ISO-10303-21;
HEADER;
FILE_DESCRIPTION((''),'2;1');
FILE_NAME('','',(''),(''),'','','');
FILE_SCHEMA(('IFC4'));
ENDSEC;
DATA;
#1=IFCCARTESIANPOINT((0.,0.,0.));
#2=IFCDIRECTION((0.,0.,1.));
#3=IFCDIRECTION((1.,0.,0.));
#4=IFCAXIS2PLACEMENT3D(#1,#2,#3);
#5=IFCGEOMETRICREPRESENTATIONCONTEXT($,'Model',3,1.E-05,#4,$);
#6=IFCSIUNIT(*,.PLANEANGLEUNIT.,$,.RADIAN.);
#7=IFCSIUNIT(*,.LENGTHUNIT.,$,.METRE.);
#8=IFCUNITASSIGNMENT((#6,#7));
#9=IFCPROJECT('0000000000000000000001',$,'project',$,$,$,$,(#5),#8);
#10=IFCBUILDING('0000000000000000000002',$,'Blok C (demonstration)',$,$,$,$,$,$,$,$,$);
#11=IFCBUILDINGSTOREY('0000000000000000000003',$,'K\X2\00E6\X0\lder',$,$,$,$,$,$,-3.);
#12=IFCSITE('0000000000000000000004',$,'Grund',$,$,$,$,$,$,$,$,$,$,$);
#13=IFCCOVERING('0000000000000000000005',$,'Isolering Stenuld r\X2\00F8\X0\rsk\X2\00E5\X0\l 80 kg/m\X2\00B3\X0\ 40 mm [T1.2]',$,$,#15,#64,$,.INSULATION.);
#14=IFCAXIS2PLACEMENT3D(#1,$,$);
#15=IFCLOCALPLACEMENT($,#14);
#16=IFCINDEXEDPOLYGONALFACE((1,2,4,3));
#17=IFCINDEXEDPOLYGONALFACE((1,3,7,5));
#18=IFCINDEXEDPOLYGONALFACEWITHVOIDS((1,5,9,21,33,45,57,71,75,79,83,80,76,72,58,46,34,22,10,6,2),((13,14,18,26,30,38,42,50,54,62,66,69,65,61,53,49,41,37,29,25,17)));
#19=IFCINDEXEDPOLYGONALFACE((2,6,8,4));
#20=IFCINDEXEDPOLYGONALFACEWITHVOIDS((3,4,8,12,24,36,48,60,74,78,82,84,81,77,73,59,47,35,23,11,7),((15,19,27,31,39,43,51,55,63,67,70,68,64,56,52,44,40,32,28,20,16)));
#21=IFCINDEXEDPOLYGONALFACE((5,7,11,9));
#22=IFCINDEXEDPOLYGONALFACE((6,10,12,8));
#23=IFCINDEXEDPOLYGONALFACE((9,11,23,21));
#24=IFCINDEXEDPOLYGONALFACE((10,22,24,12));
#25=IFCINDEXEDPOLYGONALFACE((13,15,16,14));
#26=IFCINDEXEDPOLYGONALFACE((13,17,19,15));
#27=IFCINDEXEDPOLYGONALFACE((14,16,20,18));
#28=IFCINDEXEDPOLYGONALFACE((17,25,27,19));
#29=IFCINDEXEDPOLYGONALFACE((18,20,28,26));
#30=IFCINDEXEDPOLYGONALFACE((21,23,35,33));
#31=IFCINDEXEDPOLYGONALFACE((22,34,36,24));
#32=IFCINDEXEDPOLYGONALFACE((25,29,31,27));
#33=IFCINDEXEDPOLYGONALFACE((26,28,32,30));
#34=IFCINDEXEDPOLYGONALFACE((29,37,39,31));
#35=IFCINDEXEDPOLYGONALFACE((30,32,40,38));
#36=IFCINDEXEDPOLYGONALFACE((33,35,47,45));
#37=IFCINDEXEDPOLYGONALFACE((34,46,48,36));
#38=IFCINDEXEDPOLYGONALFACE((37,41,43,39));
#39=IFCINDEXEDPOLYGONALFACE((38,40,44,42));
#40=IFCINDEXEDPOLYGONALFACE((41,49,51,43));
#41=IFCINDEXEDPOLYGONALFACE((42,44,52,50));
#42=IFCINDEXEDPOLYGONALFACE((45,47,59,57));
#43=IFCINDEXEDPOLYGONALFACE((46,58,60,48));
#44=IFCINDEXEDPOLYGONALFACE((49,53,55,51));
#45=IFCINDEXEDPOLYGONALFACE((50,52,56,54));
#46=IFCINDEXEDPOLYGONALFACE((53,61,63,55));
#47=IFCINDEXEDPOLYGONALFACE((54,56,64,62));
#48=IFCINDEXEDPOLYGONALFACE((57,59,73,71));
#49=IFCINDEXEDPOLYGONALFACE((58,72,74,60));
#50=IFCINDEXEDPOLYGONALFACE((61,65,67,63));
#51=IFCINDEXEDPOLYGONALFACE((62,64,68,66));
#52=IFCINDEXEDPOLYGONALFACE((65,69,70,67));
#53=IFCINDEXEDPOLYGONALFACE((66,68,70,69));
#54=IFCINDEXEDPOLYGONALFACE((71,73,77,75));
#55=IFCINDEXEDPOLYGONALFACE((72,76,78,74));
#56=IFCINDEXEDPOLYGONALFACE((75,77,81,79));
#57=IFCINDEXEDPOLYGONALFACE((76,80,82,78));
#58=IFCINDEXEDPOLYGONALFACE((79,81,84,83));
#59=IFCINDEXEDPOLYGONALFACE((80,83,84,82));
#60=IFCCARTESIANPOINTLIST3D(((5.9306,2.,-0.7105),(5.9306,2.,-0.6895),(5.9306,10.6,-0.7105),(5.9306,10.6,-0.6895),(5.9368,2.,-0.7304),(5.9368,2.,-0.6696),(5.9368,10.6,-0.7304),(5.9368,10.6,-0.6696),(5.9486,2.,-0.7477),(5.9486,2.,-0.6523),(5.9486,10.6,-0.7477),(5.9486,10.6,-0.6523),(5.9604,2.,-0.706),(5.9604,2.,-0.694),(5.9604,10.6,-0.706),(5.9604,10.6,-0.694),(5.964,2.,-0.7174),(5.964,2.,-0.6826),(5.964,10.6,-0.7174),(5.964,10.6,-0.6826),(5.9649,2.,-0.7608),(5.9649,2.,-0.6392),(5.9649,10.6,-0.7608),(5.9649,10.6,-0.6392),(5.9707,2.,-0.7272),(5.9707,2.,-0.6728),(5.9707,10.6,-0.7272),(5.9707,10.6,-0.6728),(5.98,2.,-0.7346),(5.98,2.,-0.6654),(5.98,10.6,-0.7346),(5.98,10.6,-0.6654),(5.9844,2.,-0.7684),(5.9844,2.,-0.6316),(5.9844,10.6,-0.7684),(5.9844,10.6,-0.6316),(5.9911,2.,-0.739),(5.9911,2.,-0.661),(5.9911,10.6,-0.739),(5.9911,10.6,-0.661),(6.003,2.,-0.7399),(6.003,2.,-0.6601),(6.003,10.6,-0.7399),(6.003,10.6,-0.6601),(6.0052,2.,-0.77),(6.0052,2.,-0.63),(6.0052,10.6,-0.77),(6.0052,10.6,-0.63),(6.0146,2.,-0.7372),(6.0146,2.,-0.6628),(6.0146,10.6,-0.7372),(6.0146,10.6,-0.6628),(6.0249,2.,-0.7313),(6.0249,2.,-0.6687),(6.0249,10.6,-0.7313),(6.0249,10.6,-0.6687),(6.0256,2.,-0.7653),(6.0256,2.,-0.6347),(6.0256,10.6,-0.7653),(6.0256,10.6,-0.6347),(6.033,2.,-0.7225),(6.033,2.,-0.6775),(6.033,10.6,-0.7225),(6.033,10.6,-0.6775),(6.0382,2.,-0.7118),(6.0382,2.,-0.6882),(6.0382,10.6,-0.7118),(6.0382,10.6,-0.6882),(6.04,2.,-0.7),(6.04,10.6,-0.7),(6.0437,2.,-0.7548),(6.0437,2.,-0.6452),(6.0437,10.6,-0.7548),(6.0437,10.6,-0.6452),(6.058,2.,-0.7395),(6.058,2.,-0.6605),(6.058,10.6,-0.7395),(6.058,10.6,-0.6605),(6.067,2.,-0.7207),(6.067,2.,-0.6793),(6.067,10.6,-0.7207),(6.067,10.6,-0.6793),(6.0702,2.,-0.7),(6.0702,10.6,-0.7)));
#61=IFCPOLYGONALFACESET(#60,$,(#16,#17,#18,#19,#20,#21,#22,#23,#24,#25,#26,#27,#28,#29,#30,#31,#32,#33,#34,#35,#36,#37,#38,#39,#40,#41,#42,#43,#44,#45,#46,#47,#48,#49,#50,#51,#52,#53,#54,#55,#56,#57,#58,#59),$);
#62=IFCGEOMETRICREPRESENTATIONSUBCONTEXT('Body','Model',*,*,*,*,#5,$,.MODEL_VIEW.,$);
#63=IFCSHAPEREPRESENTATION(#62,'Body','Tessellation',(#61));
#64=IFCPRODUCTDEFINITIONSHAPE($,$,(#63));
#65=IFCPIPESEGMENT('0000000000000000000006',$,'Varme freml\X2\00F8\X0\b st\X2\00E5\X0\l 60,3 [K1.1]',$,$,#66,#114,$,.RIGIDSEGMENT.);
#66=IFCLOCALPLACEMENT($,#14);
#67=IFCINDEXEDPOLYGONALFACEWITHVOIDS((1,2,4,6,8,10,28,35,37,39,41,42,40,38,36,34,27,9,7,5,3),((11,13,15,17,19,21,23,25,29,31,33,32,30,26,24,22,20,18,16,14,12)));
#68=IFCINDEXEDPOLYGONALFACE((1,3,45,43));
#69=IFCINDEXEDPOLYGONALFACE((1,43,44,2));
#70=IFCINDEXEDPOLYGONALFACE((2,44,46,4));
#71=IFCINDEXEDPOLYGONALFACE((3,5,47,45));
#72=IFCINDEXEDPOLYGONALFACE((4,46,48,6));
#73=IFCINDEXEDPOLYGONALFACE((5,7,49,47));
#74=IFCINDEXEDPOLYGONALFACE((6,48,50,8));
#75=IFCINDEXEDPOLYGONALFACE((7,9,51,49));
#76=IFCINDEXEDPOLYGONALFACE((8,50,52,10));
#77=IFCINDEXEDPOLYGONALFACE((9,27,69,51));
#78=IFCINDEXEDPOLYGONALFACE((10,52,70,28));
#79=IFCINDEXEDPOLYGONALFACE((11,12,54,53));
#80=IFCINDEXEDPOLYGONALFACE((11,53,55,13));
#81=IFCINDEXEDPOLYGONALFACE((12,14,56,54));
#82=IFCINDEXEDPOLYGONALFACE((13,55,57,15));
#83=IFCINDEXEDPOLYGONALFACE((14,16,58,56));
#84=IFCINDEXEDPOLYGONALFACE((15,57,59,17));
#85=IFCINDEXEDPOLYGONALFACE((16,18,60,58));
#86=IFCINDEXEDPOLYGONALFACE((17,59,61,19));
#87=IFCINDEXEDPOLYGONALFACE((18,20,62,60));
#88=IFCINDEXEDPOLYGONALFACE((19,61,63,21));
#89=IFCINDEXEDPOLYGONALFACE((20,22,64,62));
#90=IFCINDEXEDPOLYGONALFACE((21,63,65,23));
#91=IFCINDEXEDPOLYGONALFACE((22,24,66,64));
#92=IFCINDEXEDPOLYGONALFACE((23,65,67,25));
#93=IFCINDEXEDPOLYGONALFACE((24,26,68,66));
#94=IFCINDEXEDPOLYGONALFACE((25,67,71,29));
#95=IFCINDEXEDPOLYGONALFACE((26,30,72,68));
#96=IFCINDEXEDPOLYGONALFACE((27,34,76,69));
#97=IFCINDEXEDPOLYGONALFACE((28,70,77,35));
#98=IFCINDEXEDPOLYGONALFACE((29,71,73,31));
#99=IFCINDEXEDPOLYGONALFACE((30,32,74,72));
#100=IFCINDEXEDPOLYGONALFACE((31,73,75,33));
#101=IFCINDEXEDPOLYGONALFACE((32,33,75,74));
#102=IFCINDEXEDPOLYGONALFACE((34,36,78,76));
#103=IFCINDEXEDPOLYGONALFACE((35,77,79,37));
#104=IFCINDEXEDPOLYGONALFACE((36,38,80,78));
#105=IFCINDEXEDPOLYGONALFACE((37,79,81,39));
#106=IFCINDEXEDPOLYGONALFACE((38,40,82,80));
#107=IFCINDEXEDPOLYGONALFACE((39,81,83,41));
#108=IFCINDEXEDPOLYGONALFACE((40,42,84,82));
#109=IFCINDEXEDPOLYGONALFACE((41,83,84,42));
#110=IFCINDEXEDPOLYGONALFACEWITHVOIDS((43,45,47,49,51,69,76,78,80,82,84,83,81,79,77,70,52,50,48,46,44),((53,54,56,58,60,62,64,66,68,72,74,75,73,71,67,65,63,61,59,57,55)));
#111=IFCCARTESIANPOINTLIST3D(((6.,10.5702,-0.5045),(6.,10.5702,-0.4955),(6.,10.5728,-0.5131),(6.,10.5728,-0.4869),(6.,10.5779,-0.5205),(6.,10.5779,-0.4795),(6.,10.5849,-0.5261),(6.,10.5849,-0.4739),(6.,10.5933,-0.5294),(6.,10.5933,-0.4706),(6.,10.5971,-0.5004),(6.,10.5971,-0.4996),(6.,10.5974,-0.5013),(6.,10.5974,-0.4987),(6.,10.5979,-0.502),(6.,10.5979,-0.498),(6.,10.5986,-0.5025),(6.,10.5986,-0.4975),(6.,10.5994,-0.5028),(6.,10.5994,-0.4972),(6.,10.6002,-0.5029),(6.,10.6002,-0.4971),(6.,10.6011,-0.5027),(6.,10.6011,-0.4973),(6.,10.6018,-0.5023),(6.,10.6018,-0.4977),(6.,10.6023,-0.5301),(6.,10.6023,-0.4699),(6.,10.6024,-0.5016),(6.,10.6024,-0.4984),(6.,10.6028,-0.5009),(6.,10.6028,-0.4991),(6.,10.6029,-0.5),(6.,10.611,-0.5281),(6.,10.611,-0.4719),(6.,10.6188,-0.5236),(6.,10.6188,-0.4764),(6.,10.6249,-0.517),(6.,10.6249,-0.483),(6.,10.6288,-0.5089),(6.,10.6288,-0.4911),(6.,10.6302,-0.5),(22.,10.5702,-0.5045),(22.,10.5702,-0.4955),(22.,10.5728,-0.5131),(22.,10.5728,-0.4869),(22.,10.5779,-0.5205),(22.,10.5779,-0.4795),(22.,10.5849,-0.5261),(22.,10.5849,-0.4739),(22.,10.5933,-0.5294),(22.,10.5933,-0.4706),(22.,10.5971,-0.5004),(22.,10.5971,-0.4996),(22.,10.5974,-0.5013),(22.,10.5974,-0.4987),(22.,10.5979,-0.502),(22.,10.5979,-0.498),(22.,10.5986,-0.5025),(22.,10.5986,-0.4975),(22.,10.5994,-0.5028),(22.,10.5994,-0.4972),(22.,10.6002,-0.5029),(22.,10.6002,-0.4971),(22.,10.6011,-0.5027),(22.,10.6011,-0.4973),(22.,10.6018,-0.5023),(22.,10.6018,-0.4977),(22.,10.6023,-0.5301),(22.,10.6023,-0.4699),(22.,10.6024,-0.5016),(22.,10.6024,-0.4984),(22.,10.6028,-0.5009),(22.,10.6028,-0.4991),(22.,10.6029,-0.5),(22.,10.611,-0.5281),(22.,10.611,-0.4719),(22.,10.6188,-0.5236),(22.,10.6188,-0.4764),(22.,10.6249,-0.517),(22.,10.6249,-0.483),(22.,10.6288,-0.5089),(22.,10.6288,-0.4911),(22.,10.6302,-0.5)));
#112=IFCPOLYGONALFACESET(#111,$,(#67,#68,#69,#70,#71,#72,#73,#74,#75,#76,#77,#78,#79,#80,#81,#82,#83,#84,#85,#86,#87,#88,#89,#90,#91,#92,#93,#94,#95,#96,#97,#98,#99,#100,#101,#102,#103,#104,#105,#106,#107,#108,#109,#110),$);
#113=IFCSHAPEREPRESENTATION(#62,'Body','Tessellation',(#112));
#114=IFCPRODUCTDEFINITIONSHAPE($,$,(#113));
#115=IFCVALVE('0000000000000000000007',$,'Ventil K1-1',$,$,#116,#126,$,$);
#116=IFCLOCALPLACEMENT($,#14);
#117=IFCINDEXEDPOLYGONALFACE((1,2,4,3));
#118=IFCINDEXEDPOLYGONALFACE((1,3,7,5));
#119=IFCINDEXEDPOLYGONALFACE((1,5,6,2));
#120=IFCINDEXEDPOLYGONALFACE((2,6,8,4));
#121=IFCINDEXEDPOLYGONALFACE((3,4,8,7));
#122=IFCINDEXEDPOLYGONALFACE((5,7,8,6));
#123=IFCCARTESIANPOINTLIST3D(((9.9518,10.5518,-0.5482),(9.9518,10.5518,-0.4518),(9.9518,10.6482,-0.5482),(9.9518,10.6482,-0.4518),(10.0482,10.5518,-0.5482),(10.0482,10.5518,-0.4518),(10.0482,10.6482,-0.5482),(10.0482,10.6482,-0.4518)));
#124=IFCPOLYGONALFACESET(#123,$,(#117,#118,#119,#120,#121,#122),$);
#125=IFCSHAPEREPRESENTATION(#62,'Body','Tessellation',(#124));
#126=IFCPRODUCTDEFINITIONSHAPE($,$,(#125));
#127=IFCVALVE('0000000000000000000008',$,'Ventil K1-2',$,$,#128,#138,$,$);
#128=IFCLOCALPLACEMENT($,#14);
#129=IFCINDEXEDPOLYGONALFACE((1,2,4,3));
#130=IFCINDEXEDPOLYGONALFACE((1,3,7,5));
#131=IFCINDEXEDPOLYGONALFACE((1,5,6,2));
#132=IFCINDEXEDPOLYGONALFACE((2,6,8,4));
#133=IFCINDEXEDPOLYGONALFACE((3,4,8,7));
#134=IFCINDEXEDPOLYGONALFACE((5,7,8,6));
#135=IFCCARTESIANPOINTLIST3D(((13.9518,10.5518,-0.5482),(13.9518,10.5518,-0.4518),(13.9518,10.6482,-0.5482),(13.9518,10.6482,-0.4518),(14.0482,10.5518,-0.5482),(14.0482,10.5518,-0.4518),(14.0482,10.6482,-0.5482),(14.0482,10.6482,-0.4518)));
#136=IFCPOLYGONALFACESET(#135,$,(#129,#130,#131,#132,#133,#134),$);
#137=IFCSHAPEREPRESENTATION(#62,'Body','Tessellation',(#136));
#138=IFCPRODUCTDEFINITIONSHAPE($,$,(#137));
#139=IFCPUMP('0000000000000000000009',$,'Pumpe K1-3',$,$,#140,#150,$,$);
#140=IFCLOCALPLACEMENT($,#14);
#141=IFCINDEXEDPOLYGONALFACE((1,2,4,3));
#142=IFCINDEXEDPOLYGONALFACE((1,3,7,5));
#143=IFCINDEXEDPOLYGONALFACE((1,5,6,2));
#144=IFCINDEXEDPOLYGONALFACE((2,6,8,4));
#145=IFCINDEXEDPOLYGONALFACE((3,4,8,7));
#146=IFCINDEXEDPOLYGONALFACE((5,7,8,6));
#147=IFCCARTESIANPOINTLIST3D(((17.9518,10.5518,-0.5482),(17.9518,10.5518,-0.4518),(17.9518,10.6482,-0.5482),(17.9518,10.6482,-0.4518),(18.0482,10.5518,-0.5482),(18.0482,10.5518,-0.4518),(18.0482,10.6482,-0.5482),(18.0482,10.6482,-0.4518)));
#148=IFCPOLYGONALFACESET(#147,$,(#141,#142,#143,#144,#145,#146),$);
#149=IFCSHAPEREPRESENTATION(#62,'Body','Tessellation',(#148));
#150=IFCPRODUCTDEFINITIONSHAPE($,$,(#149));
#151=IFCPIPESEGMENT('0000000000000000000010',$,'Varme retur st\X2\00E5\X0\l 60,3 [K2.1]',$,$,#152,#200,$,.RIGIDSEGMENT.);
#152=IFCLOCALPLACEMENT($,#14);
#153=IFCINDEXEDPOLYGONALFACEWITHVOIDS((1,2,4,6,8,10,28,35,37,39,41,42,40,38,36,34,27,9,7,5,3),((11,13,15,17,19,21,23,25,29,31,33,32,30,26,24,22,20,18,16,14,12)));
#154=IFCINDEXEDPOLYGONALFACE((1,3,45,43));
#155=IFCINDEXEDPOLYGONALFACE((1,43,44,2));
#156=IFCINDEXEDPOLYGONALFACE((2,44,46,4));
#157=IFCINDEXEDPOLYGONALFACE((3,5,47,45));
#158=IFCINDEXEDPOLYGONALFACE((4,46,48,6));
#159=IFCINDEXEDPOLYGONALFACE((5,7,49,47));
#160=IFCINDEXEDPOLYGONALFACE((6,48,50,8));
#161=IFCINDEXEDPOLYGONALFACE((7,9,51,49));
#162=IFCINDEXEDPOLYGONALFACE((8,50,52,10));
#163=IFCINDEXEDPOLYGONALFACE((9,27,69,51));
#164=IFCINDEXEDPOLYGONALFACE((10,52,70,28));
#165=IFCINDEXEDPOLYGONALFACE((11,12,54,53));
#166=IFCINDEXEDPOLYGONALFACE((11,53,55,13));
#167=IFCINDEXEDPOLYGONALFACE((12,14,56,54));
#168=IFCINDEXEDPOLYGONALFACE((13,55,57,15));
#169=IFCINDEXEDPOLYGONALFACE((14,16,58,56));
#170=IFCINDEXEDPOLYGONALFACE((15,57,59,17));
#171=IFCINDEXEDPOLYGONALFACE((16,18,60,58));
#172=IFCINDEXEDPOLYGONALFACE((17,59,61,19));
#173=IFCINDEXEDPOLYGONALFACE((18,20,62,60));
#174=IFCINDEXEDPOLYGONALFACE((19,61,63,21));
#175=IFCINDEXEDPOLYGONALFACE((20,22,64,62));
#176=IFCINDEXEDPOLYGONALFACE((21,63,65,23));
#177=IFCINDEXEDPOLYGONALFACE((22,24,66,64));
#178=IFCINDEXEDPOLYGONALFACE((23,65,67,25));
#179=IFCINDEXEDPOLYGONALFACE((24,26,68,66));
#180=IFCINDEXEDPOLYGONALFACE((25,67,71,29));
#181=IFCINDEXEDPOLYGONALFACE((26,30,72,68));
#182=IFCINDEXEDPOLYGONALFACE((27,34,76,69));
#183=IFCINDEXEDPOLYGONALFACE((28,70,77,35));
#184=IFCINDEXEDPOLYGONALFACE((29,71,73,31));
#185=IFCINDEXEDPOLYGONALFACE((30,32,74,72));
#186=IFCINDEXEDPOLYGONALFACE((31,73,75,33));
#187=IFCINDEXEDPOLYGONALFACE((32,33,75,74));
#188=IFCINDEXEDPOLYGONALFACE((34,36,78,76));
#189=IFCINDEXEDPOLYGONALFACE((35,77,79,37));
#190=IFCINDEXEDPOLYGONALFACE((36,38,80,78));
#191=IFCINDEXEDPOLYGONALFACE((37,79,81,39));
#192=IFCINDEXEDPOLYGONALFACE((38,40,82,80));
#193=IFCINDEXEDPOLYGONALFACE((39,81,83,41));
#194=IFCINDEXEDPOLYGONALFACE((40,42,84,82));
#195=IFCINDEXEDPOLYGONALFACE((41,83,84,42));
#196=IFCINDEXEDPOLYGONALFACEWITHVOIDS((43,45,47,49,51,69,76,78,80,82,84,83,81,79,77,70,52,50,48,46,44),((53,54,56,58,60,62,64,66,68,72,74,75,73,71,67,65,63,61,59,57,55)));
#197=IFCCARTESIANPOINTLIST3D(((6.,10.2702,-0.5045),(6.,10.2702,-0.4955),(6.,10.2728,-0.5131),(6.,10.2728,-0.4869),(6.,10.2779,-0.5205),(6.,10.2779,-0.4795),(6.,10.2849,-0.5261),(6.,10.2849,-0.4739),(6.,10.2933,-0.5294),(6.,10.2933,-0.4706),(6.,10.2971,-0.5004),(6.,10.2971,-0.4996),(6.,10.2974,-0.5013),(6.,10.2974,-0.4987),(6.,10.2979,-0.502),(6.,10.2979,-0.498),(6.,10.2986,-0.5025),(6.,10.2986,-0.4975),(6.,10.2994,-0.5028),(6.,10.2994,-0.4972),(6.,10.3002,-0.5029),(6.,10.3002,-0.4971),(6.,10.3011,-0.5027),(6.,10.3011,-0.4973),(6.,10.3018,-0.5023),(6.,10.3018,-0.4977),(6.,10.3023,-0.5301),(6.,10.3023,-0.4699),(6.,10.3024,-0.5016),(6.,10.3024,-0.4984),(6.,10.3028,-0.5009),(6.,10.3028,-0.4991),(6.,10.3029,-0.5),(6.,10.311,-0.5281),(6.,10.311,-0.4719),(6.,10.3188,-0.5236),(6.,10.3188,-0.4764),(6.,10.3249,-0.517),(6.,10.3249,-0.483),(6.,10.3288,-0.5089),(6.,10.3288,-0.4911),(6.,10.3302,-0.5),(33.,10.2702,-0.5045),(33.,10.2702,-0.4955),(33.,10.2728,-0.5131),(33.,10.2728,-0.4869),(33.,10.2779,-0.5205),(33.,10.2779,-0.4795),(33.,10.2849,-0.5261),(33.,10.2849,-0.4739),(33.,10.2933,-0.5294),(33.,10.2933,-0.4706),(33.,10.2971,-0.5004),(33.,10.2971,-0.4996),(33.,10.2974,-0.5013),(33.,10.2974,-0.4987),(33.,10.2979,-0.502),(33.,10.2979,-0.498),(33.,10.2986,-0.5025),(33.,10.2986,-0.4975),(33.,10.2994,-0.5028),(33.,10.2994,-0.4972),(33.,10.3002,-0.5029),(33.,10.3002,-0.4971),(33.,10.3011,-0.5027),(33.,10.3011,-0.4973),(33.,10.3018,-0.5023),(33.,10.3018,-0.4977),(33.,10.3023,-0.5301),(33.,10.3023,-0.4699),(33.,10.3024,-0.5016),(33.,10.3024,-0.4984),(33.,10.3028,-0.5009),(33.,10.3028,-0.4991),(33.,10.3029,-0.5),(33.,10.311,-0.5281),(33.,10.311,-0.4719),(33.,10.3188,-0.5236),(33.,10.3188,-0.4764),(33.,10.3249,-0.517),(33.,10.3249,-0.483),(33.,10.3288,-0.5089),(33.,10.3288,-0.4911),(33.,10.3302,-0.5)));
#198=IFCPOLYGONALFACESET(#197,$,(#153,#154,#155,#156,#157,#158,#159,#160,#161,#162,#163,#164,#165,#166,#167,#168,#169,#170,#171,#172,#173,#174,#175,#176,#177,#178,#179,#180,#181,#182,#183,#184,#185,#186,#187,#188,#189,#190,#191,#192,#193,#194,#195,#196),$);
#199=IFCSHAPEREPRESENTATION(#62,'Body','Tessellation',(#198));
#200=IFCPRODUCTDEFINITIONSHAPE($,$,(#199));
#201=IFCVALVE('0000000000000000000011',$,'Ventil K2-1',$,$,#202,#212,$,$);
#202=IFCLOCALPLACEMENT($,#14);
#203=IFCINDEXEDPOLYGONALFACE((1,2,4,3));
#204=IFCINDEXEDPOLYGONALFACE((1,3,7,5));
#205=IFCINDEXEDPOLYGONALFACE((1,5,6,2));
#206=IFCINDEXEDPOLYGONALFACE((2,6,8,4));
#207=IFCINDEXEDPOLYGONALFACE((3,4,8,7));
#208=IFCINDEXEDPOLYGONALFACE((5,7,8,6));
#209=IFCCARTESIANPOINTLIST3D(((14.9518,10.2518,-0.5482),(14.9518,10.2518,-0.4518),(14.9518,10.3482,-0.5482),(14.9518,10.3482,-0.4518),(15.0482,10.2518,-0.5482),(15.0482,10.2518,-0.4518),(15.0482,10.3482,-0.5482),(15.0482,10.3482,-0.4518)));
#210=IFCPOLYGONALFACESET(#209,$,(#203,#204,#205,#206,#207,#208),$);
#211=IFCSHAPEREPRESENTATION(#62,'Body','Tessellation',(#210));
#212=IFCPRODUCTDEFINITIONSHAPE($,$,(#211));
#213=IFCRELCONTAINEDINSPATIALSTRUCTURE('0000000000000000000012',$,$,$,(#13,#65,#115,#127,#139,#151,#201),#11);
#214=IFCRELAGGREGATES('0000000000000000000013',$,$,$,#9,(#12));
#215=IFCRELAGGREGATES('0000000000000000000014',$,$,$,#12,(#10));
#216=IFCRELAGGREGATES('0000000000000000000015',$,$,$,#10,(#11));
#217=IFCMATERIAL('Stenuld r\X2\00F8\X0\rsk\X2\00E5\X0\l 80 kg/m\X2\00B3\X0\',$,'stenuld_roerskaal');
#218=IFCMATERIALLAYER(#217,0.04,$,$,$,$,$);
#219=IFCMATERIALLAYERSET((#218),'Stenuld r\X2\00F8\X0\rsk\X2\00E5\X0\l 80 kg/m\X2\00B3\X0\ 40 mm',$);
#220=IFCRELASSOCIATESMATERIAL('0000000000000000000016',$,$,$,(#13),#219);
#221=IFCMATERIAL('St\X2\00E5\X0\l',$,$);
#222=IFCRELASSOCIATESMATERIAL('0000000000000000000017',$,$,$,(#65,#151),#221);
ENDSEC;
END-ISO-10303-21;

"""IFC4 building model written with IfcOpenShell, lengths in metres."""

from ifc_helpers import new_model, si_unit, frame, origin_with_axes, place, context, subcontext, project, spatial, polyline, hollow_circle, outline, extrude, material, layer, layer_set, element, save


model = new_model("IFC4")

# Units and contexts
model_context = context("Model", 3, precision=1e-05, world=origin_with_axes())
body_context = subcontext(model_context, "Body", "Model", "MODEL_VIEW")
ifc_project = project(units=[si_unit("PLANEANGLEUNIT", "RADIAN"), si_unit("LENGTHUNIT", "METRE")], contexts=[model_context])

# Site, building, storey
site = spatial("IfcSite", under=ifc_project, Name="Grund")
building = spatial("IfcBuilding", under=site, Name="Blok C (demonstration)")
storey = spatial("IfcBuildingStorey", under=building, Name="Kælder", Elevation=-3.0)

# Covering
ifc_material_1 = material(Name="Stenuld rørskål 80 kg/m³", Category="stenuld_roerskaal")
ifc_layer_1 = layer(ifc_material_1, 0.04)
ifc_layer_set_1 = layer_set([ifc_layer_1], Name="Stenuld rørskål 80 kg/m³ 40 mm")
covering_1_placement = place(None, origin_with_axes())
element("IfcCovering", 1, at=covering_1_placement, inside=storey, material=ifc_layer_set_1, Name="Isolering Stenuld rørskål 80 kg/m³ 40 mm [T1.2]", PredefinedType="INSULATION", context=body_context, shape_type="SweptSolid", body=[
    extrude(hollow_circle(Radius=0.0702, WallThickness=0.0302), frame((6.0, 2.0, -0.7), z_axis=(0.0, 1.0, 0.0), x_axis=(1.0, 0.0, 0.0)), (0.0, 0.0, 1.0), 8.6),
])

# Pipe segment
ifc_material_2 = material(Name="Stål")
pipe_segment_1_placement = place(None, origin_with_axes())
element("IfcPipeSegment", 2, at=pipe_segment_1_placement, inside=storey, material=ifc_material_2, Name="Varme fremløb stål 60,3 [K1.1]", PredefinedType="RIGIDSEGMENT", context=body_context, shape_type="SweptSolid", body=[
    extrude(hollow_circle(Radius=0.0301, WallThickness=0.0272), frame((6.0, 10.6, -0.5), z_axis=(1.0, 0.0, 0.0), x_axis=(0.0, 1.0, 0.0)), (0.0, 0.0, 1.0), 16.0),
])

# Valves
valve_1_placement = place(None, origin_with_axes())
element("IfcValve", 3, at=valve_1_placement, inside=storey, Name="Ventil K1-1", context=body_context, shape_type="SweptSolid", body=[
    extrude(outline(polyline([(9.9518, 10.5518), (10.0482, 10.5518), (10.0482, 10.6482), (9.9518, 10.6482), (9.9518, 10.5518)])), frame((0.0, 0.0, -0.5482)), (0.0, 0.0, 1.0), 0.0965),
])
valve_2_placement = place(None, origin_with_axes())
element("IfcValve", 4, at=valve_2_placement, inside=storey, Name="Ventil K1-2", context=body_context, shape_type="SweptSolid", body=[
    extrude(outline(polyline([(13.9518, 10.5518), (14.0482, 10.5518), (14.0482, 10.6482), (13.9518, 10.6482), (13.9518, 10.5518)])), frame((0.0, 0.0, -0.5482)), (0.0, 0.0, 1.0), 0.0965),
])

# Pump
pump_placement = place(None, origin_with_axes())
element("IfcPump", 5, at=pump_placement, inside=storey, Name="Pumpe K1-3", context=body_context, shape_type="SweptSolid", body=[
    extrude(outline(polyline([(17.9518, 10.5518), (18.0482, 10.5518), (18.0482, 10.6482), (17.9518, 10.6482), (17.9518, 10.5518)])), frame((0.0, 0.0, -0.5482)), (0.0, 0.0, 1.0), 0.0965),
])

# Pipe segment
pipe_segment_2_placement = place(None, origin_with_axes())
element("IfcPipeSegment", 6, at=pipe_segment_2_placement, inside=storey, material=ifc_material_2, Name="Varme retur stål 60,3 [K2.1]", PredefinedType="RIGIDSEGMENT", context=body_context, shape_type="SweptSolid", body=[
    extrude(hollow_circle(Radius=0.0301, WallThickness=0.0272), frame((6.0, 10.3, -0.5), z_axis=(1.0, 0.0, 0.0), x_axis=(0.0, 1.0, 0.0)), (0.0, 0.0, 1.0), 27.0),
])

# Valve
valve_3_placement = place(None, origin_with_axes())
element("IfcValve", 7, at=valve_3_placement, inside=storey, Name="Ventil K2-1", context=body_context, shape_type="SweptSolid", body=[
    extrude(outline(polyline([(14.9518, 10.2518), (15.0482, 10.2518), (15.0482, 10.3482), (14.9518, 10.3482), (14.9518, 10.2518)])), frame((0.0, 0.0, -0.5482)), (0.0, 0.0, 1.0), 0.0965),
])

save(model, "model.ifc")
